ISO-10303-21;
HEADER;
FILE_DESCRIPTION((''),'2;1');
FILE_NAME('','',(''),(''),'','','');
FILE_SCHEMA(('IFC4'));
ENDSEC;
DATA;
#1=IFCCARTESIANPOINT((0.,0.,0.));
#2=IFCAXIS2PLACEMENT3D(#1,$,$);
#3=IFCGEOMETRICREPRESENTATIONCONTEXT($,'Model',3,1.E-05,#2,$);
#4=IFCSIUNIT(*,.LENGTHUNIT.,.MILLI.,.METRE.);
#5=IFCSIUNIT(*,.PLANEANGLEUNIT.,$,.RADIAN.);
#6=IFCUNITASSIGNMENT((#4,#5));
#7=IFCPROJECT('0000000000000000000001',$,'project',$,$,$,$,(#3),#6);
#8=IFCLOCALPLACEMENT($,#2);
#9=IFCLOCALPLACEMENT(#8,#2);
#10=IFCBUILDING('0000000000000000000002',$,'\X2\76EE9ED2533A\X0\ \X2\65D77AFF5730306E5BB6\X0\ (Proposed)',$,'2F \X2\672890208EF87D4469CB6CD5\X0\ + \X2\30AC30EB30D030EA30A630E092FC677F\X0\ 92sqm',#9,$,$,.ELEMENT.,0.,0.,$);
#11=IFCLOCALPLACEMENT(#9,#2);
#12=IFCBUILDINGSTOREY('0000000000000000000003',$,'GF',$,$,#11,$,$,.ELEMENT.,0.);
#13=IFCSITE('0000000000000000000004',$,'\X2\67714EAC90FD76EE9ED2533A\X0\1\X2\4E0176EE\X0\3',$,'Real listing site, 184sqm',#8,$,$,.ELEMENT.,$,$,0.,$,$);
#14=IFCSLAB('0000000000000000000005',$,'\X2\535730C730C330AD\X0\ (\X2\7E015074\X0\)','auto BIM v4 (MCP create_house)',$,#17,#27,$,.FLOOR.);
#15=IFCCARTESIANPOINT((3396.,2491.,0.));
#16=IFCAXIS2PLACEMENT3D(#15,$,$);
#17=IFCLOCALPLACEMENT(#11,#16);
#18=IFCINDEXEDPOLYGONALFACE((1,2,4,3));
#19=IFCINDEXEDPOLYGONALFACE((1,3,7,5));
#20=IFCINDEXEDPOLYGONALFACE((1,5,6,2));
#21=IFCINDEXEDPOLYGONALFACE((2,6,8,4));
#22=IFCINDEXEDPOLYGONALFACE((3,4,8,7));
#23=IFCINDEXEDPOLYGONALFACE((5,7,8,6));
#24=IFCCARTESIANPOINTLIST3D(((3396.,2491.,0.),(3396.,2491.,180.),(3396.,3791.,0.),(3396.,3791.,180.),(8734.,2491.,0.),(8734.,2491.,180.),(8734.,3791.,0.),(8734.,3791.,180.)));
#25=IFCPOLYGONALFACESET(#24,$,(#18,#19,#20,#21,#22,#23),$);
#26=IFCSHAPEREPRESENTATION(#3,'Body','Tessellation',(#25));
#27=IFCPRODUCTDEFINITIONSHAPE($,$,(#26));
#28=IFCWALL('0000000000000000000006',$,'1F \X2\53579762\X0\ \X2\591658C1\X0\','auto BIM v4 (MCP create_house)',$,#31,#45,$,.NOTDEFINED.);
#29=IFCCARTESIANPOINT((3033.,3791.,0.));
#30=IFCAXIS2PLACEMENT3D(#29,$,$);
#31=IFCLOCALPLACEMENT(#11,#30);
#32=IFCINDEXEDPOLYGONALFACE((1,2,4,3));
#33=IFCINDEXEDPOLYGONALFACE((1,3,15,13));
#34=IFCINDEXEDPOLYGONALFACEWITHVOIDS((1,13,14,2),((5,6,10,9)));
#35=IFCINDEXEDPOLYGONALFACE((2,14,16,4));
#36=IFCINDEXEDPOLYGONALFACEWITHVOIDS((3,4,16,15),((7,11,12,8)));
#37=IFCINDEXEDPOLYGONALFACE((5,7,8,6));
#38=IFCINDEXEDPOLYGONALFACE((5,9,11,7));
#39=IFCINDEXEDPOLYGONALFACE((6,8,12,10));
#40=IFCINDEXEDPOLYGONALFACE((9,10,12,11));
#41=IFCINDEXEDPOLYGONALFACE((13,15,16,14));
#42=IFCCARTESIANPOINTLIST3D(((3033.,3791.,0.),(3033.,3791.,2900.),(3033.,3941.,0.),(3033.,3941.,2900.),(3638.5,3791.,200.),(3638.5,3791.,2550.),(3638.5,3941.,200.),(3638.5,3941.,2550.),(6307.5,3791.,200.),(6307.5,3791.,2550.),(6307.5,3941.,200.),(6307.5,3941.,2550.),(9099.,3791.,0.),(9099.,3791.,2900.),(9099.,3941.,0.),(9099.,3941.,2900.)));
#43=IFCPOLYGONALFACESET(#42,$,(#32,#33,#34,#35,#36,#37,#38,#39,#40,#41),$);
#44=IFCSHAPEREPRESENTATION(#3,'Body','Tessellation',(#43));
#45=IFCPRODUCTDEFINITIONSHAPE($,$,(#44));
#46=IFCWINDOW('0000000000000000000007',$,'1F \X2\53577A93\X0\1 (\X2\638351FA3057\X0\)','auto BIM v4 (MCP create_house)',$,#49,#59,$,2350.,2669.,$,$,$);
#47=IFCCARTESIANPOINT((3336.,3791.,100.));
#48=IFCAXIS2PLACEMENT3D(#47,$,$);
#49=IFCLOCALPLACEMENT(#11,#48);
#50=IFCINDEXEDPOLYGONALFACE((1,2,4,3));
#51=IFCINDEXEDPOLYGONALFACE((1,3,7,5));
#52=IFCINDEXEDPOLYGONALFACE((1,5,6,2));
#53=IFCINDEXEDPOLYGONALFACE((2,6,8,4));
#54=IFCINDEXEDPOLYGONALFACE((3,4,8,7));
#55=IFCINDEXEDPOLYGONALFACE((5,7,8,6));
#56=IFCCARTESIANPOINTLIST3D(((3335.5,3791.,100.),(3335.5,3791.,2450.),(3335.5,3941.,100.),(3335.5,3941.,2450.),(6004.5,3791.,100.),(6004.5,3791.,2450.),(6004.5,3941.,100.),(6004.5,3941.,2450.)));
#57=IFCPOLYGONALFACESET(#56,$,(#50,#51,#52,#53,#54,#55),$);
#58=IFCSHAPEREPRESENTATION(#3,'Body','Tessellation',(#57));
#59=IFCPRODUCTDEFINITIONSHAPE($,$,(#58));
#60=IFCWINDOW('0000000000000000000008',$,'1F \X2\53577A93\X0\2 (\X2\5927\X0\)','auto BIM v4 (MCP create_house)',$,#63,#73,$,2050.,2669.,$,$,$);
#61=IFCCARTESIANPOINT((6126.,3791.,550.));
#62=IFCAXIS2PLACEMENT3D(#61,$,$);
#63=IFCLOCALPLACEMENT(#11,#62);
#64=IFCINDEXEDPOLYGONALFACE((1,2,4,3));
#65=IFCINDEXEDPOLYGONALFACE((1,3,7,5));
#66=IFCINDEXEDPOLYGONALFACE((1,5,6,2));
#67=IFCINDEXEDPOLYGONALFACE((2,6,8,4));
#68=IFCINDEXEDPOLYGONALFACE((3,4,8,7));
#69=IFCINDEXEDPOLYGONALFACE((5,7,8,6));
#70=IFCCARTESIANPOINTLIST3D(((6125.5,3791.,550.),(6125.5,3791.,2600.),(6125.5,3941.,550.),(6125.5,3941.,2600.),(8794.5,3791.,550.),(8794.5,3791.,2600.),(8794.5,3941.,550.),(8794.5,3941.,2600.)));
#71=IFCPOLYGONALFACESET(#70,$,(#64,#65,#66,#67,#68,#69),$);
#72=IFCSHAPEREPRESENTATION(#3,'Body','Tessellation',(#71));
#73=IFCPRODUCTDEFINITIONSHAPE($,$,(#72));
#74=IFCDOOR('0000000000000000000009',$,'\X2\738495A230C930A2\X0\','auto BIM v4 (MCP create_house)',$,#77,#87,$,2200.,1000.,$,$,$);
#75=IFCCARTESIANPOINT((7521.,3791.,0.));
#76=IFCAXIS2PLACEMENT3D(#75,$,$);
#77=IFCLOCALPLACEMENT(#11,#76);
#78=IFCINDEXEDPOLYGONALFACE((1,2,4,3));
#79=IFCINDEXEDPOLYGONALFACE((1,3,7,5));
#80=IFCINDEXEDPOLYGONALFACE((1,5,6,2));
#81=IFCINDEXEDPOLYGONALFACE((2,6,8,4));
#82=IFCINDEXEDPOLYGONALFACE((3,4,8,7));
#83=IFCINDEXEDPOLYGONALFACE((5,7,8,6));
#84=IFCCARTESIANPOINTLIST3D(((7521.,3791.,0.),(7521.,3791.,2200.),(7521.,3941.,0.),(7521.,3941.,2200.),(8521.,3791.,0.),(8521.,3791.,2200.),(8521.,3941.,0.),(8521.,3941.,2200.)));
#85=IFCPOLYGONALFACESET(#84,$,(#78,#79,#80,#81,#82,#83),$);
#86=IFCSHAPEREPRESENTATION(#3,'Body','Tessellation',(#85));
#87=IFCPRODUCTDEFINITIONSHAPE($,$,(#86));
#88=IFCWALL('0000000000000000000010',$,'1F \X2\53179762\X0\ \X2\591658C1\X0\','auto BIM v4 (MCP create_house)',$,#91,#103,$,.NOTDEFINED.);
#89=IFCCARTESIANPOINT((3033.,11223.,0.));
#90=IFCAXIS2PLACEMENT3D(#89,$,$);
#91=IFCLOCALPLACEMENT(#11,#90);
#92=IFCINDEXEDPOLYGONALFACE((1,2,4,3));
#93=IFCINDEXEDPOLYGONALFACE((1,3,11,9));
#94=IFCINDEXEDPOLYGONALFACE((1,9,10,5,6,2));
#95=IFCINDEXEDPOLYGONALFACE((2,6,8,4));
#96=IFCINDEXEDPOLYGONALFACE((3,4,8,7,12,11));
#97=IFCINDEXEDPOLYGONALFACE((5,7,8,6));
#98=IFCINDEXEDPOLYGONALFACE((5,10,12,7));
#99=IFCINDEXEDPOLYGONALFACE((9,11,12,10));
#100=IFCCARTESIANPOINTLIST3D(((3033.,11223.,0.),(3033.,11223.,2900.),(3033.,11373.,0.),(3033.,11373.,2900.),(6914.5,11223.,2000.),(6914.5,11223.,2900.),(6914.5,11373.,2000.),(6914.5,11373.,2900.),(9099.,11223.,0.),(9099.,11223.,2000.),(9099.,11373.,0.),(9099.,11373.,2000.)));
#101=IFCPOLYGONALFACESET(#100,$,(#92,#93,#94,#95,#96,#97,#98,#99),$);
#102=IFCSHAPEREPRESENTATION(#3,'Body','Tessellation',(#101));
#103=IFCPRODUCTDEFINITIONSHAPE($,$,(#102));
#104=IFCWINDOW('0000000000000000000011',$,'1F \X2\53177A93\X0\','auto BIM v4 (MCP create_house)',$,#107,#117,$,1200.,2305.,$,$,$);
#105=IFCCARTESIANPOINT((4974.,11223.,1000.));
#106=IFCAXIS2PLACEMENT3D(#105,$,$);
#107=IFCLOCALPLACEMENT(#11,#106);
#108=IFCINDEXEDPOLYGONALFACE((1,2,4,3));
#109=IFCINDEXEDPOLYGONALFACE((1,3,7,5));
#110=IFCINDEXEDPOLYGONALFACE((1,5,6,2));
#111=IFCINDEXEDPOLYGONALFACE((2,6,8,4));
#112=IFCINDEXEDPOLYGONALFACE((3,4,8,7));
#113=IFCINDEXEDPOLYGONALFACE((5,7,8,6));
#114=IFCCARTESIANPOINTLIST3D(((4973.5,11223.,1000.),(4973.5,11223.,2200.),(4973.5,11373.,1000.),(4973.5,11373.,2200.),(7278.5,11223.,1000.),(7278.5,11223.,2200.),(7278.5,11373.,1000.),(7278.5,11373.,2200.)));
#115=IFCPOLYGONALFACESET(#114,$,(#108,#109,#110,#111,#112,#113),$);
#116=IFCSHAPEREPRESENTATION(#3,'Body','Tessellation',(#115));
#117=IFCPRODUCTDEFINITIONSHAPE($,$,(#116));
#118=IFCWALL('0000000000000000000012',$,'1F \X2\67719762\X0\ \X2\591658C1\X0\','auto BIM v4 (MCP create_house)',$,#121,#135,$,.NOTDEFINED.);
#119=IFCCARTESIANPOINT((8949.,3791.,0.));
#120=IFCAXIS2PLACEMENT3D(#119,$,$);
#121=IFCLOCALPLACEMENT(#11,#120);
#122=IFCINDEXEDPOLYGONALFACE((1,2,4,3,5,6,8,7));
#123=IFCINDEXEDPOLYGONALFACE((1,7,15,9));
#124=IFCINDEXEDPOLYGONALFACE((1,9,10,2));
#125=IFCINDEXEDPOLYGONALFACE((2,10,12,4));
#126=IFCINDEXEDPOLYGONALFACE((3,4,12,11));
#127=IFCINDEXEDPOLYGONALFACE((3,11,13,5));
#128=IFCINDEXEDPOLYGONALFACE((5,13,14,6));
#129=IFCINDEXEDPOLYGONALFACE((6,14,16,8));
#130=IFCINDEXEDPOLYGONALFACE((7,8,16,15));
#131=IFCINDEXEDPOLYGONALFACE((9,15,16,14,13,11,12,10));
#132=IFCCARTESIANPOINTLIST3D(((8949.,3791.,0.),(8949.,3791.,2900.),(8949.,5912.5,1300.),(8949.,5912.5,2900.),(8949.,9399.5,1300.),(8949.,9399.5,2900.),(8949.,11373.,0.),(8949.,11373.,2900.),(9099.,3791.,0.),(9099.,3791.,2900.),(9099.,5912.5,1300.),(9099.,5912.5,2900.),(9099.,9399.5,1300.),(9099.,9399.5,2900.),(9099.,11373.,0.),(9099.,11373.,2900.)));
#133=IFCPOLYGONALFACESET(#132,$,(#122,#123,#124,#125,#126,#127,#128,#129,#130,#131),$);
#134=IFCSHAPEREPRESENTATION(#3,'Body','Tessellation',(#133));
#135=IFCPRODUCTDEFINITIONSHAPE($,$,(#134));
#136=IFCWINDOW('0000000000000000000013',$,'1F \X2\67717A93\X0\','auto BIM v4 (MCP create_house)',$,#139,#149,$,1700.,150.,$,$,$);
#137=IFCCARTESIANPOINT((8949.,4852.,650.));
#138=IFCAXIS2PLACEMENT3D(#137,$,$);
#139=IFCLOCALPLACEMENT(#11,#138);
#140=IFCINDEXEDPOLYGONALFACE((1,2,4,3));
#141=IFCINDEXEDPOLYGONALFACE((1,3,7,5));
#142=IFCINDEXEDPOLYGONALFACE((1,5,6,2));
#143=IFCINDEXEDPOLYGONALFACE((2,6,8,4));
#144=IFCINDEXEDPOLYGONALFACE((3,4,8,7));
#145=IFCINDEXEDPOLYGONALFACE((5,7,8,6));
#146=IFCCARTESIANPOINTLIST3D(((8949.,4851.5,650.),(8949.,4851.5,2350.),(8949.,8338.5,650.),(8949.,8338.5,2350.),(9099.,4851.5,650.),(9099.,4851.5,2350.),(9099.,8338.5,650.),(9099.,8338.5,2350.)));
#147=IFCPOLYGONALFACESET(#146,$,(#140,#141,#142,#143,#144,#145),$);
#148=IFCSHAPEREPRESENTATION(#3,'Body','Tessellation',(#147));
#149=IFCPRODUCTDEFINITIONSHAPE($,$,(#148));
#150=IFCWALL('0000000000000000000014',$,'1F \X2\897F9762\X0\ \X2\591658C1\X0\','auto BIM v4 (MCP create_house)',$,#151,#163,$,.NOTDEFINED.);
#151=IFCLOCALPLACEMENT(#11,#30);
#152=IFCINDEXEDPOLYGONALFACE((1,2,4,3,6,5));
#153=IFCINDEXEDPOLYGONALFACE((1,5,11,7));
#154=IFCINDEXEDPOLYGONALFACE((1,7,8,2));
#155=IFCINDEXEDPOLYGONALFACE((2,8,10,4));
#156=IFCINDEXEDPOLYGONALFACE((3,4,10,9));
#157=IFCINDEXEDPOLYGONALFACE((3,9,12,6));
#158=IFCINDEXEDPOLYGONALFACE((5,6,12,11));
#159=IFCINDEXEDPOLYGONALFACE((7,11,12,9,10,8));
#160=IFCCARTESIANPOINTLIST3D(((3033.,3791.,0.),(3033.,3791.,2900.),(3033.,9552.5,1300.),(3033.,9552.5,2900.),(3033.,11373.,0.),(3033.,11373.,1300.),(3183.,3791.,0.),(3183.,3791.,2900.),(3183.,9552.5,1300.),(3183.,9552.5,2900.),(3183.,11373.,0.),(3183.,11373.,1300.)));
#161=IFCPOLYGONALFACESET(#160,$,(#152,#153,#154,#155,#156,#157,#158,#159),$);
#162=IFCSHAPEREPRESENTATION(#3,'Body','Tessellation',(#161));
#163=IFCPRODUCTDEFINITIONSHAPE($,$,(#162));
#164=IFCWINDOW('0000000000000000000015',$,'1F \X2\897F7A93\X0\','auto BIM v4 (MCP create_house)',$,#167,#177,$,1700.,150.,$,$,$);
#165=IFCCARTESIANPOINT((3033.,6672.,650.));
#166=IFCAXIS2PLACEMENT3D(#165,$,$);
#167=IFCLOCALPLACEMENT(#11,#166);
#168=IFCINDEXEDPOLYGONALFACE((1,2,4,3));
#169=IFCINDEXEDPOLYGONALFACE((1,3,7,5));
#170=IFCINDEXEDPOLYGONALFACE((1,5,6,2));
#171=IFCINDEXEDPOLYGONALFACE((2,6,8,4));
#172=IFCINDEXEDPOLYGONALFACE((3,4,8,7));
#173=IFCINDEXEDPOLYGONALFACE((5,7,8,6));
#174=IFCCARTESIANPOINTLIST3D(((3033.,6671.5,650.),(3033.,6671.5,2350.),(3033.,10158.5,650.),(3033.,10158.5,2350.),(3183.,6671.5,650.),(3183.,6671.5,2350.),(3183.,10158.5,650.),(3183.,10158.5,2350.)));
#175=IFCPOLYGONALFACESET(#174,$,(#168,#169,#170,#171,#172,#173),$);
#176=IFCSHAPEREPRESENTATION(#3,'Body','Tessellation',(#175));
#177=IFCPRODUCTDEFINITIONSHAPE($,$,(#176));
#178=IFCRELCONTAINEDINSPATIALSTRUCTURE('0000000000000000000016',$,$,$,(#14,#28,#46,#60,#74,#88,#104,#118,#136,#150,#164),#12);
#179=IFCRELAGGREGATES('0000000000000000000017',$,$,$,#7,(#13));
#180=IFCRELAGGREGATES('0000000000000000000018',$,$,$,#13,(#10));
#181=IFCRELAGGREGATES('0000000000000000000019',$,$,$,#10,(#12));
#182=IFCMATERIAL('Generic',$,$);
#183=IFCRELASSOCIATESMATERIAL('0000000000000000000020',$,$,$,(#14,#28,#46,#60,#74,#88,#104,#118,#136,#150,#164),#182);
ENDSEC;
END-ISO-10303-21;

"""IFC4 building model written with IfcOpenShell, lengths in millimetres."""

from ifc_helpers import new_model, si_unit, frame, frame_2d, origin, place, context, project, spatial, rectangle, extrude, material, element, fill, save


model = new_model("IFC4")

# Units and contexts
model_context = context("Model", 3, precision=1e-05, world=origin())
ifc_project = project(units=[si_unit("LENGTHUNIT", "METRE", prefix="MILLI"), si_unit("PLANEANGLEUNIT", "RADIAN")], contexts=[model_context])

# Site, building, storey
site_placement = place(None, origin())
site = spatial("IfcSite", under=ifc_project, at=site_placement, Name="東京都目黒区1丁目3", ObjectType="Real listing site, 184sqm", CompositionType="ELEMENT", RefElevation=0.0)
building_placement = place(site_placement, origin())
building = spatial("IfcBuilding", under=site, at=building_placement, Name="目黒区 旗竿地の家 (Proposed)", ObjectType="2F 木造軸組構法 + ガルバリウム鋼板 92sqm", CompositionType="ELEMENT", ElevationOfRefHeight=0.0, ElevationOfTerrain=0.0)
storey_placement = place(building_placement, origin())
storey = spatial("IfcBuildingStorey", under=building, at=storey_placement, Name="GF", CompositionType="ELEMENT", Elevation=0.0)

# Slab
ifc_material = material(Name="Generic")
slab_1_placement = place(storey_placement, frame((3396.0, 2491.0, 0.0)))
element("IfcSlab", 1, at=slab_1_placement, inside=storey, material=ifc_material, Name="南デッキ (縁側)", Description="auto BIM v4 (MCP create_house)", PredefinedType="FLOOR", context=model_context, shape_type="SweptSolid", body=[
    extrude(rectangle(XDim=5338.0, YDim=1300.0, at=frame_2d((2669.0, 650.0))), frame((3396.0, 2491.0, 0.0)), (0.0, 0.0, 1.0), 180.0),
])

# Wall, openings, windows, door
wall_1_placement = place(storey_placement, frame((3033.0, 3791.0, 0.0)))
wall_1 = element("IfcWall", 2, at=wall_1_placement, inside=storey, material=ifc_material, Name="1F 南面 外壁", Description="auto BIM v4 (MCP create_house)", PredefinedType="NOTDEFINED", context=model_context, shape_type="SweptSolid", body=[
    extrude(rectangle(XDim=6066.0, YDim=150.0, at=frame_2d((3033.0, 75.0))), frame((3033.0, 3791.0, 0.0)), (0.0, 0.0, 1.0), 2900.0),
])
opening_1_placement = place(storey_placement, frame((3336.0, 3791.0, 100.0)))
opening_1 = element("IfcOpeningElement", 3, at=opening_1_placement, cuts=wall_1, PredefinedType="NOTDEFINED", context=model_context, shape_type="SweptSolid", body=[
    extrude(rectangle(XDim=2669.0, YDim=150.0, at=frame_2d((1334.0, 75.0))), frame((3336.0, 3791.0, 100.0)), (0.0, 0.0, 1.0), 2350.0),
])
opening_2_placement = place(storey_placement, frame((6126.0, 3791.0, 550.0)))
opening_2 = element("IfcOpeningElement", 4, at=opening_2_placement, cuts=wall_1, PredefinedType="NOTDEFINED", context=model_context, shape_type="SweptSolid", body=[
    extrude(rectangle(XDim=2669.0, YDim=150.0, at=frame_2d((1334.0, 75.0))), frame((6126.0, 3791.0, 550.0)), (0.0, 0.0, 1.0), 2050.0),
])
opening_3_placement = place(storey_placement, frame((7521.0, 3791.0, 0.0)))
opening_3 = element("IfcOpeningElement", 5, at=opening_3_placement, cuts=wall_1, PredefinedType="NOTDEFINED", context=model_context, shape_type="SweptSolid", body=[
    extrude(rectangle(XDim=1000.0, YDim=150.0, at=frame_2d((500.0, 75.0))), frame((7521.0, 3791.0, 0.0)), (0.0, 0.0, 1.0), 2200.0),
])
window_1_placement = place(storey_placement, frame((3336.0, 3791.0, 100.0)))
window_1 = element("IfcWindow", 6, at=window_1_placement, inside=storey, material=ifc_material, Name="1F 南窓1 (掃出し)", Description="auto BIM v4 (MCP create_house)", OverallHeight=2350.0, OverallWidth=2669.0, context=model_context, shape_type="SweptSolid", body=[
    extrude(rectangle(XDim=2669.0, YDim=150.0, at=frame_2d((1334.0, 75.0))), frame((3336.0, 3791.0, 100.0)), (0.0, 0.0, 1.0), 2350.0),
])
fill(opening_1, window_1)
window_2_placement = place(storey_placement, frame((6126.0, 3791.0, 550.0)))
window_2 = element("IfcWindow", 7, at=window_2_placement, inside=storey, material=ifc_material, Name="1F 南窓2 (大)", Description="auto BIM v4 (MCP create_house)", OverallHeight=2050.0, OverallWidth=2669.0, context=model_context, shape_type="SweptSolid", body=[
    extrude(rectangle(XDim=2669.0, YDim=150.0, at=frame_2d((1334.0, 75.0))), frame((6126.0, 3791.0, 550.0)), (0.0, 0.0, 1.0), 2050.0),
])
fill(opening_2, window_2)
door_1_placement = place(storey_placement, frame((7521.0, 3791.0, 0.0)))
door_1 = element("IfcDoor", 8, at=door_1_placement, inside=storey, material=ifc_material, Name="玄関ドア", Description="auto BIM v4 (MCP create_house)", OverallHeight=2200.0, OverallWidth=1000.0, context=model_context, shape_type="SweptSolid", body=[
    extrude(rectangle(XDim=1000.0, YDim=150.0, at=frame_2d((500.0, 75.0))), frame((7521.0, 3791.0, 0.0)), (0.0, 0.0, 1.0), 2200.0),
])
fill(opening_3, door_1)

# Walls, openings, windows
wall_2_placement = place(storey_placement, frame((3033.0, 11223.0, 0.0)))
wall_2 = element("IfcWall", 9, at=wall_2_placement, inside=storey, material=ifc_material, Name="1F 北面 外壁", Description="auto BIM v4 (MCP create_house)", PredefinedType="NOTDEFINED", context=model_context, shape_type="SweptSolid", body=[
    extrude(rectangle(XDim=6066.0, YDim=150.0, at=frame_2d((3033.0, 75.0))), frame((3033.0, 11223.0, 0.0)), (0.0, 0.0, 1.0), 2900.0),
])
opening_4_placement = place(storey_placement, frame((4974.0, 11223.0, 1000.0)))
opening_4 = element("IfcOpeningElement", 10, at=opening_4_placement, cuts=wall_2, PredefinedType="NOTDEFINED", context=model_context, shape_type="SweptSolid", body=[
    extrude(rectangle(XDim=2305.0, YDim=150.0, at=frame_2d((1152.0, 75.0))), frame((4974.0, 11223.0, 1000.0)), (0.0, 0.0, 1.0), 1200.0),
])
window_3_placement = place(storey_placement, frame((4974.0, 11223.0, 1000.0)))
window_3 = element("IfcWindow", 11, at=window_3_placement, inside=storey, material=ifc_material, Name="1F 北窓", Description="auto BIM v4 (MCP create_house)", OverallHeight=1200.0, OverallWidth=2305.0, context=model_context, shape_type="SweptSolid", body=[
    extrude(rectangle(XDim=2305.0, YDim=150.0, at=frame_2d((1152.0, 75.0))), frame((4974.0, 11223.0, 1000.0)), (0.0, 0.0, 1.0), 1200.0),
])
fill(opening_4, window_3)
wall_3_placement = place(storey_placement, frame((8949.0, 3791.0, 0.0)))
wall_3 = element("IfcWall", 12, at=wall_3_placement, inside=storey, material=ifc_material, Name="1F 東面 外壁", Description="auto BIM v4 (MCP create_house)", PredefinedType="NOTDEFINED", context=model_context, shape_type="SweptSolid", body=[
    extrude(rectangle(XDim=150.0, YDim=7582.0, at=frame_2d((75.0, 3791.0))), frame((8949.0, 3791.0, 0.0)), (0.0, 0.0, 1.0), 2900.0),
])
opening_5_placement = place(storey_placement, frame((8949.0, 4852.0, 650.0)))
opening_5 = element("IfcOpeningElement", 13, at=opening_5_placement, cuts=wall_3, PredefinedType="NOTDEFINED", context=model_context, shape_type="SweptSolid", body=[
    extrude(rectangle(XDim=150.0, YDim=3487.0, at=frame_2d((75.0, 1743.0))), frame((8949.0, 4852.0, 650.0)), (0.0, 0.0, 1.0), 1700.0),
])
window_4_placement = place(storey_placement, frame((8949.0, 4852.0, 650.0)))
window_4 = element("IfcWindow", 14, at=window_4_placement, inside=storey, material=ifc_material, Name="1F 東窓", Description="auto BIM v4 (MCP create_house)", OverallHeight=1700.0, OverallWidth=150.0, context=model_context, shape_type="SweptSolid", body=[
    extrude(rectangle(XDim=150.0, YDim=3487.0, at=frame_2d((75.0, 1743.0))), frame((8949.0, 4852.0, 650.0)), (0.0, 0.0, 1.0), 1700.0),
])
fill(opening_5, window_4)
wall_4_placement = place(storey_placement, frame((3033.0, 3791.0, 0.0)))
wall_4 = element("IfcWall", 15, at=wall_4_placement, inside=storey, material=ifc_material, Name="1F 西面 外壁", Description="auto BIM v4 (MCP create_house)", PredefinedType="NOTDEFINED", context=model_context, shape_type="SweptSolid", body=[
    extrude(rectangle(XDim=150.0, YDim=7582.0, at=frame_2d((75.0, 3791.0))), frame((3033.0, 3791.0, 0.0)), (0.0, 0.0, 1.0), 2900.0),
])
opening_6_placement = place(storey_placement, frame((3033.0, 6672.0, 650.0)))
opening_6 = element("IfcOpeningElement", 16, at=opening_6_placement, cuts=wall_4, PredefinedType="NOTDEFINED", context=model_context, shape_type="SweptSolid", body=[
    extrude(rectangle(XDim=150.0, YDim=3487.0, at=frame_2d((75.0, 1743.0))), frame((3033.0, 6672.0, 650.0)), (0.0, 0.0, 1.0), 1700.0),
])
window_5_placement = place(storey_placement, frame((3033.0, 6672.0, 650.0)))
window_5 = element("IfcWindow", 17, at=window_5_placement, inside=storey, material=ifc_material, Name="1F 西窓", Description="auto BIM v4 (MCP create_house)", OverallHeight=1700.0, OverallWidth=150.0, context=model_context, shape_type="SweptSolid", body=[
    extrude(rectangle(XDim=150.0, YDim=3487.0, at=frame_2d((75.0, 1743.0))), frame((3033.0, 6672.0, 650.0)), (0.0, 0.0, 1.0), 1700.0),
])
fill(opening_6, window_5)

save(model, "model.ifc")
